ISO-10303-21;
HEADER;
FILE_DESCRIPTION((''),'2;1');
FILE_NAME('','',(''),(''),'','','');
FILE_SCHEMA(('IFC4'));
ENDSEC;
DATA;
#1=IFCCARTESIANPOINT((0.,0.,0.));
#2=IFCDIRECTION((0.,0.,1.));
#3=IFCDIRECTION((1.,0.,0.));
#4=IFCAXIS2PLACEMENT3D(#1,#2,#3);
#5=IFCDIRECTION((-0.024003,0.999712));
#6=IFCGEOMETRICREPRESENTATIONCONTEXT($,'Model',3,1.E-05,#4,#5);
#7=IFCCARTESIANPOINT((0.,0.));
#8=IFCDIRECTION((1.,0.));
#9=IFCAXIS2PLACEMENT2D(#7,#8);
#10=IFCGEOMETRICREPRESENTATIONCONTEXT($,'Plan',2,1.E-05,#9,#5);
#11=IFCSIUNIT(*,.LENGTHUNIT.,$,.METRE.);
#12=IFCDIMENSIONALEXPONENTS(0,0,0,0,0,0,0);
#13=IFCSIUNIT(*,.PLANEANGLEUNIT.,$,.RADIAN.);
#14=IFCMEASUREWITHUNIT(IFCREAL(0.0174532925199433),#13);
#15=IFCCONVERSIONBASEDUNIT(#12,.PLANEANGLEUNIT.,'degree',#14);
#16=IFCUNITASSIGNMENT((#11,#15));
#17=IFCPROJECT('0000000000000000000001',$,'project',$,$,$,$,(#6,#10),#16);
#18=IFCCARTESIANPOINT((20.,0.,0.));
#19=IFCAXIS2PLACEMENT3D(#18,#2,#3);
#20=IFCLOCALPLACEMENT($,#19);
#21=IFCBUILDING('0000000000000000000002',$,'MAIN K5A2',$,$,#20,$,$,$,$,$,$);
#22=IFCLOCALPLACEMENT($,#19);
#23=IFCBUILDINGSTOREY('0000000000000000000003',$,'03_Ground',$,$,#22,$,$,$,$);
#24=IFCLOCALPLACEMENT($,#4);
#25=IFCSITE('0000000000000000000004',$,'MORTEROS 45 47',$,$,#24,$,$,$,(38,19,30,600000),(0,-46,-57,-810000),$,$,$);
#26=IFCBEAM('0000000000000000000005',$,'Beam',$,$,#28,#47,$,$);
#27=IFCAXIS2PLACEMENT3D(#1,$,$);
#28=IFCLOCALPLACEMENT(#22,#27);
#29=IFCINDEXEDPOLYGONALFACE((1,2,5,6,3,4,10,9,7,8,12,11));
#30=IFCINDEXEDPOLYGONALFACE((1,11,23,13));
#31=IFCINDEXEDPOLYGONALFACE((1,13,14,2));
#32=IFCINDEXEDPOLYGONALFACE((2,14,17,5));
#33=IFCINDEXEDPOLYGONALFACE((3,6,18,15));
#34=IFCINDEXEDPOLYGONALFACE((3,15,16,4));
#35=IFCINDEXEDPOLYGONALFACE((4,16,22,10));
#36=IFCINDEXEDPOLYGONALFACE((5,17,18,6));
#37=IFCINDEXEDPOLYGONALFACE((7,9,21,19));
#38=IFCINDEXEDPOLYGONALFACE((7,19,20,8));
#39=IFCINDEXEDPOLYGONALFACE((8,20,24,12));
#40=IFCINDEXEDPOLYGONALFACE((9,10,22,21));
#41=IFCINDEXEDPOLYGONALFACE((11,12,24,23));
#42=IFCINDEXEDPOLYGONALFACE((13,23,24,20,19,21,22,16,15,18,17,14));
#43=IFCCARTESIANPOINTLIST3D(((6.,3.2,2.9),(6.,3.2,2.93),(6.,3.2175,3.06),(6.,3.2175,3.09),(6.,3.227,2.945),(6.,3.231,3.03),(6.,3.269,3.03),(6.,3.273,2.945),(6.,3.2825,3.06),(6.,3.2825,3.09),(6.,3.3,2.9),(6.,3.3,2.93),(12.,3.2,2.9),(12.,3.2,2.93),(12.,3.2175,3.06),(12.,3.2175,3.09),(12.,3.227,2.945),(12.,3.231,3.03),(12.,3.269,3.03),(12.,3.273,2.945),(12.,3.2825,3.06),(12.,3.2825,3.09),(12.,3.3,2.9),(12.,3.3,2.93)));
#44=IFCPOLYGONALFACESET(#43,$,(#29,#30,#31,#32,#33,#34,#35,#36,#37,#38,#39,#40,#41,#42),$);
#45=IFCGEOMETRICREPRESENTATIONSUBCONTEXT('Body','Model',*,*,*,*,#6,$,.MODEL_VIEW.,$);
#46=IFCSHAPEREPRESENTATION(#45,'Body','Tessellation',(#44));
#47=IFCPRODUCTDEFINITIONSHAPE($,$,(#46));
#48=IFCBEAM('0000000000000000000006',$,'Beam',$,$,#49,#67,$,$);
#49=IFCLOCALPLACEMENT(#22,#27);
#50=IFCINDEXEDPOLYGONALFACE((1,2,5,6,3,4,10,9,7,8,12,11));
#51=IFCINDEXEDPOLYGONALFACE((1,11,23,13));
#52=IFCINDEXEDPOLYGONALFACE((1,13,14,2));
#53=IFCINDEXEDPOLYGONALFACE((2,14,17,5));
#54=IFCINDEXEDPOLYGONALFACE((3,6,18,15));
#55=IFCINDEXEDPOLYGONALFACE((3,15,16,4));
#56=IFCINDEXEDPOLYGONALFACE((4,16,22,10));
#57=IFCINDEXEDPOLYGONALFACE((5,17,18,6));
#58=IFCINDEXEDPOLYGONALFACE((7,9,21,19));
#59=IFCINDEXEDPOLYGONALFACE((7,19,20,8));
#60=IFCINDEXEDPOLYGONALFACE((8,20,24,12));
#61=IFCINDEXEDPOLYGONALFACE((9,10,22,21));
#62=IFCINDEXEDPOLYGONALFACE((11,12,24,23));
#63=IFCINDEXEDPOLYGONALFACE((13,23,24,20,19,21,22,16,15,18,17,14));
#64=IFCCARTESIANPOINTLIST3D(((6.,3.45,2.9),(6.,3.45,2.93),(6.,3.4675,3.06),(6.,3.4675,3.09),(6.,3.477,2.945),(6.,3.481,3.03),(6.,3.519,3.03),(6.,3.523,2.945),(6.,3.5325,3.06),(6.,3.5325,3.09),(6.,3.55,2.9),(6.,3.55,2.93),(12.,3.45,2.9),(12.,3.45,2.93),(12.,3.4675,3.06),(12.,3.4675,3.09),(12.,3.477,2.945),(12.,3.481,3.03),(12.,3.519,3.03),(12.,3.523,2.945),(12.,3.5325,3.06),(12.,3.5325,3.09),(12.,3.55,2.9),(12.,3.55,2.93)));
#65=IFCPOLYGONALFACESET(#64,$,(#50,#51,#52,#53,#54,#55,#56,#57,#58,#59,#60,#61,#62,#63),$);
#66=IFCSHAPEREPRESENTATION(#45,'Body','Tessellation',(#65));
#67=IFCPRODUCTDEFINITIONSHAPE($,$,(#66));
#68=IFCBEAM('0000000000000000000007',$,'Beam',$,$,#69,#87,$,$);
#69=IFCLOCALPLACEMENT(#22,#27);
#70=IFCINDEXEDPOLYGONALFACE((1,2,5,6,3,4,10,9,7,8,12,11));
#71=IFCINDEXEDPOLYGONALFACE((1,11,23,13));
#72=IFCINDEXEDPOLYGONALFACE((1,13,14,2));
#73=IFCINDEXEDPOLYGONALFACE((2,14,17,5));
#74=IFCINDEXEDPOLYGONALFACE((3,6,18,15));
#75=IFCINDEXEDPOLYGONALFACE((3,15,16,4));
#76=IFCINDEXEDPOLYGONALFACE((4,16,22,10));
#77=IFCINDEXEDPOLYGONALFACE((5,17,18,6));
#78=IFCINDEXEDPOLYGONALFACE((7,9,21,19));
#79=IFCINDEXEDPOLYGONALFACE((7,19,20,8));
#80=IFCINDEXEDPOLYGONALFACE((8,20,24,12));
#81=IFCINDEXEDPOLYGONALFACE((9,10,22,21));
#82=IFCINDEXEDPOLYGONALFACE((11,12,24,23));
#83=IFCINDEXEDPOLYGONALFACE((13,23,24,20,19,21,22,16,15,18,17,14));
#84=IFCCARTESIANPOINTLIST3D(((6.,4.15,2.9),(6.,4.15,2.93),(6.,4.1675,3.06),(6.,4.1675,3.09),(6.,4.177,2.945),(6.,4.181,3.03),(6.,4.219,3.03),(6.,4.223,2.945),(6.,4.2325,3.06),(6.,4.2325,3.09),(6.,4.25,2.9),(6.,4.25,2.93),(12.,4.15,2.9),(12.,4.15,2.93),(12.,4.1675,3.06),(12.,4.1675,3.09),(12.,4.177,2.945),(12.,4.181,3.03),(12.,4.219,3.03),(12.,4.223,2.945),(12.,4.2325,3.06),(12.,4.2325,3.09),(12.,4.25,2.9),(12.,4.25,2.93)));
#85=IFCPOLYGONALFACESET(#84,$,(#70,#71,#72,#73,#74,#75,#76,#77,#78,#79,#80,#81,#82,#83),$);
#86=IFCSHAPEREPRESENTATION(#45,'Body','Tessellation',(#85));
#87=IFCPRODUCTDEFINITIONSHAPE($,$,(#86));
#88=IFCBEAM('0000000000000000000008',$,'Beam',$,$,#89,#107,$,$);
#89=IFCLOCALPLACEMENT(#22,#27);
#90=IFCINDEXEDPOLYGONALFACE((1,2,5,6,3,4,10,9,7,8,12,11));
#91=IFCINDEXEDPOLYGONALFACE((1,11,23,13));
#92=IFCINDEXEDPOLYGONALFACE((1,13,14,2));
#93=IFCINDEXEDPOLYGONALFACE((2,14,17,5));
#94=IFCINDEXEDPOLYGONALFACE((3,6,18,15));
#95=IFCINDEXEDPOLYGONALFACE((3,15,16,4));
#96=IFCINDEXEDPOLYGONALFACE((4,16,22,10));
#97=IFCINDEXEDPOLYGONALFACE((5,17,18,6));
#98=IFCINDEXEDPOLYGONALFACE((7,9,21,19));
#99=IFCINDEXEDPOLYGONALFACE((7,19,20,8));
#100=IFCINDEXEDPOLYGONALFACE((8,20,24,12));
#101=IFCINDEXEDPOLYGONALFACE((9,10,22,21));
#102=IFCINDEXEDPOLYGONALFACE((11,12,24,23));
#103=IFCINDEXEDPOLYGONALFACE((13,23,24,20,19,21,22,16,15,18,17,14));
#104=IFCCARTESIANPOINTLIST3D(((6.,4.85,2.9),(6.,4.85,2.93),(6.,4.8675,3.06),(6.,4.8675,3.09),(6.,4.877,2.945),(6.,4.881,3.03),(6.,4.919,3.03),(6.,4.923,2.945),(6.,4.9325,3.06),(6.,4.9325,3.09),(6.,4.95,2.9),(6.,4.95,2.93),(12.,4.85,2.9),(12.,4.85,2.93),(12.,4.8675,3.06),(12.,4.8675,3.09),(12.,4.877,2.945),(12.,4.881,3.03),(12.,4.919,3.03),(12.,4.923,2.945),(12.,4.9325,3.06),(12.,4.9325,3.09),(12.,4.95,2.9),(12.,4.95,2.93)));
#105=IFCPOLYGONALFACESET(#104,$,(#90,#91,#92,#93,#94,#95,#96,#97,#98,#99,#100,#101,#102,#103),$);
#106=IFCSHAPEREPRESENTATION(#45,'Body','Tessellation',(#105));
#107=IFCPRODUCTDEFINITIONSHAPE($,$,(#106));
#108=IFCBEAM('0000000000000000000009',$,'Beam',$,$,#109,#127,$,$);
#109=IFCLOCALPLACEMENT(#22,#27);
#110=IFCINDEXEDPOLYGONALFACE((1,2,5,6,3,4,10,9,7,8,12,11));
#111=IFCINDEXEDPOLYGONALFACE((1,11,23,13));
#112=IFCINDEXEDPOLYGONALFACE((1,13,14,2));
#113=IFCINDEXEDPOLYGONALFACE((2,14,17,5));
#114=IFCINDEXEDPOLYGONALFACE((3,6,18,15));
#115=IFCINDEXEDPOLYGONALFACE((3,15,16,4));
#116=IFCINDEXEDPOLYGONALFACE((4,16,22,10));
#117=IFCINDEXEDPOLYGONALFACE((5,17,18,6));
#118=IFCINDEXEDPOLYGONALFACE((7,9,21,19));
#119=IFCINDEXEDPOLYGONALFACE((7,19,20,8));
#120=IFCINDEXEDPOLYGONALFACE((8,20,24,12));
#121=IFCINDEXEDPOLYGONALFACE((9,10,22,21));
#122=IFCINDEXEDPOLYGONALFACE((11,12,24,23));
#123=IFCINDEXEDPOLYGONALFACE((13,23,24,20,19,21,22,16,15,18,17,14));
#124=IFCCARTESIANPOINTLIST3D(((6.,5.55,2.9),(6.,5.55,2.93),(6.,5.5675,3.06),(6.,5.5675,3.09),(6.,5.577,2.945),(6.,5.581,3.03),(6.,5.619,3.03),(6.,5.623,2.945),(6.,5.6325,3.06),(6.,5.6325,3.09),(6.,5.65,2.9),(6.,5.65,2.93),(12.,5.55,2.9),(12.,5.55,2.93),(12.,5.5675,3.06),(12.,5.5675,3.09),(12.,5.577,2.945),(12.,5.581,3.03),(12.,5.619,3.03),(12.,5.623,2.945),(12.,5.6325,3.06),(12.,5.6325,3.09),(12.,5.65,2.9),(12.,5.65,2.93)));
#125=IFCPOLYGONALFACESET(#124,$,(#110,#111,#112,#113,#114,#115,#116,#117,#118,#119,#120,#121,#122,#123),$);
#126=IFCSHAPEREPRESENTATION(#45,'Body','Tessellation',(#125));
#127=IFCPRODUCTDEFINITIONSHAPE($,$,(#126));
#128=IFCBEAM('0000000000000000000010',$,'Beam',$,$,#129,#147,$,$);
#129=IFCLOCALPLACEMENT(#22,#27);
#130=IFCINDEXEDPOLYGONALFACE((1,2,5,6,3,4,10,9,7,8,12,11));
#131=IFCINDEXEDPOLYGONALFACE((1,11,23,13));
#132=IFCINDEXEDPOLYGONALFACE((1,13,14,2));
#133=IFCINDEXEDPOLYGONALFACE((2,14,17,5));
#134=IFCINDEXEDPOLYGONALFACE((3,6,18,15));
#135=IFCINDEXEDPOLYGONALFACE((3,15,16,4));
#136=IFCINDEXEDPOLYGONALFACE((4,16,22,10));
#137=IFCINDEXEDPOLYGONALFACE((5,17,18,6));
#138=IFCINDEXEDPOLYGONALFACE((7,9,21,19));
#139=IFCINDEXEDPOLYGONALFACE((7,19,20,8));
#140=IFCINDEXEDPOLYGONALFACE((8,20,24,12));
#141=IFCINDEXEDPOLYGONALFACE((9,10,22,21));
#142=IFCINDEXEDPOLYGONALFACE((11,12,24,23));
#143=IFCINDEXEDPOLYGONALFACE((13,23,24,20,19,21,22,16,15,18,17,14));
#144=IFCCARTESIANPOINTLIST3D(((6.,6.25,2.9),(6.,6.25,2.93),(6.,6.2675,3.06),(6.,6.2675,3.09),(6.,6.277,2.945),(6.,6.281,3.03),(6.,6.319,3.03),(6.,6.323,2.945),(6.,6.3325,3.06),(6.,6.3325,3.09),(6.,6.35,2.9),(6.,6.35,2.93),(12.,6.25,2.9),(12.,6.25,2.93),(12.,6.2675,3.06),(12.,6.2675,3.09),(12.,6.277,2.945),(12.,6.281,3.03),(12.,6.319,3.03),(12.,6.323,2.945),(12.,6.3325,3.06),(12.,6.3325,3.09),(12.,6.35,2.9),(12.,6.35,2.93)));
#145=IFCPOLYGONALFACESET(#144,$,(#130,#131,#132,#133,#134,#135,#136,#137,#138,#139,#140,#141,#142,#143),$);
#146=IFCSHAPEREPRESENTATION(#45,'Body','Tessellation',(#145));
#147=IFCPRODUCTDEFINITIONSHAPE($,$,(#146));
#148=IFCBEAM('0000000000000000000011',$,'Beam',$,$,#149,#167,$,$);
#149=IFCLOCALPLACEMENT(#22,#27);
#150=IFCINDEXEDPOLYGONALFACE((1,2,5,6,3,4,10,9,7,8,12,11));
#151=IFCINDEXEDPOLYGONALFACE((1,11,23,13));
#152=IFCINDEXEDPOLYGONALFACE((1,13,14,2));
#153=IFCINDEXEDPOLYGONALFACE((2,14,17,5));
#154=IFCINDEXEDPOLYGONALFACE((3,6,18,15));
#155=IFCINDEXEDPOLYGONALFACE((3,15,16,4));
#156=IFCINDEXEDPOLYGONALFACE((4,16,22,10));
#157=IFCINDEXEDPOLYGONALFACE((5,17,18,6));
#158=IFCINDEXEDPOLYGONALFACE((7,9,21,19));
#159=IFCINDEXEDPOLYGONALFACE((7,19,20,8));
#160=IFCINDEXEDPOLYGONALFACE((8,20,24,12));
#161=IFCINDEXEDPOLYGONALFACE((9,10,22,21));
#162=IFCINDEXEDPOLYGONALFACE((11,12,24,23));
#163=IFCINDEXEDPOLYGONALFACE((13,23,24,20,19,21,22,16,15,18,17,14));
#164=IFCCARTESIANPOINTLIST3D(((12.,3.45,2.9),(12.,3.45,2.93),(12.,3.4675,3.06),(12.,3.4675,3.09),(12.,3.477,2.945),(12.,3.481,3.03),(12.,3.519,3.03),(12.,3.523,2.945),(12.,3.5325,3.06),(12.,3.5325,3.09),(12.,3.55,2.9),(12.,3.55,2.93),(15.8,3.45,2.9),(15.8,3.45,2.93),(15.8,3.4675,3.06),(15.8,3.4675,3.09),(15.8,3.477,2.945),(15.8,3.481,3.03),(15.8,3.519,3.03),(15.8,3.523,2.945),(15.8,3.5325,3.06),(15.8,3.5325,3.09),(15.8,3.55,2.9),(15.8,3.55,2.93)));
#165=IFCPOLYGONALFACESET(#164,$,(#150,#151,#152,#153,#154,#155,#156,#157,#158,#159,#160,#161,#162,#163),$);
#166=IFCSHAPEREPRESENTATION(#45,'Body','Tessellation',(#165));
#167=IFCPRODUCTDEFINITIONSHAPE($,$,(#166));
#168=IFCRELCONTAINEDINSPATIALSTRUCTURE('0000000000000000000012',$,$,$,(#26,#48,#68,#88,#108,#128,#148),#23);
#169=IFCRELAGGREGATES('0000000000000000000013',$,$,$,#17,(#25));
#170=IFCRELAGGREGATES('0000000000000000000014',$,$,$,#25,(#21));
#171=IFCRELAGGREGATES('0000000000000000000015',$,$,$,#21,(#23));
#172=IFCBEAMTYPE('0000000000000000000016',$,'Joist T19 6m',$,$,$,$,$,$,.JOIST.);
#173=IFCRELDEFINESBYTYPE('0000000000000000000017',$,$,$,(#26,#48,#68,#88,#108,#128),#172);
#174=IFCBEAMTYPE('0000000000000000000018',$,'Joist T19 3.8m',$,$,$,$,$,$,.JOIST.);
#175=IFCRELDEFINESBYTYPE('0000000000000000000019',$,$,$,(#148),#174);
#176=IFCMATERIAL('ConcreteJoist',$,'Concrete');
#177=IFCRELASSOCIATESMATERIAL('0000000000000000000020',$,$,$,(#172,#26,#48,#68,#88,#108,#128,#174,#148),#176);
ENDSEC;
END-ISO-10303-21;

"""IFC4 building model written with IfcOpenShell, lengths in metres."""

from ifc_helpers import new_model, entity, si_unit, converted_unit, direction, frame, origin_with_axes, origin_2d_with_axis, place, context, subcontext, project, spatial, indexed_curve, outline, extrude, material, material_profile, profile_set, profile_usage, type_object, element, save


model = new_model("IFC4")

# Units and contexts
model_context = context("Model", 3, precision=1e-05, world=origin_with_axes(), true_north=direction((-0.024003, 0.999712)))
plan_context = context("Plan", 2, precision=1e-05, world=origin_2d_with_axis(), true_north=direction((-0.024003, 0.999712)))
body_context_1 = subcontext(model_context, "Body", "Model", "MODEL_VIEW")
ifc_project = project(units=[si_unit("LENGTHUNIT", "METRE"), converted_unit("PLANEANGLEUNIT", "degree", entity("IfcReal", 0.0174532925199433), si_unit("PLANEANGLEUNIT", "RADIAN"), dimensions=[0, 0, 0, 0, 0, 0, 0])], contexts=[model_context, plan_context])

# Site, building, storey
site_placement = place(None, origin_with_axes())
site = spatial("IfcSite", under=ifc_project, at=site_placement, Name="MORTEROS 45 47", RefLatitude=(38, 19, 30, 600000), RefLongitude=(0, -46, -57, -810000))
building_placement = place(None, frame((20.0, 0.0, 0.0), z_axis=(0.0, 0.0, 1.0), x_axis=(1.0, 0.0, 0.0)))
building = spatial("IfcBuilding", under=site, at=building_placement, Name="MAIN K5A2")
storey_placement = place(None, frame((20.0, 0.0, 0.0), z_axis=(0.0, 0.0, 1.0), x_axis=(1.0, 0.0, 0.0)))
storey = spatial("IfcBuildingStorey", under=building, at=storey_placement, Name="03_Ground")

# Beams
ifc_material = material(Name="ConcreteJoist", Category="Concrete")
ifc_material_profile_1 = material_profile(ifc_material, outline(indexed_curve([(0.019, 0.13), (0.023, 0.045), (0.05, 0.03), (0.05, 0.0), (-0.05, 0.0), (-0.05, 0.03), (-0.023, 0.045), (-0.019, 0.13), (-0.0325, 0.16), (-0.0325, 0.19), (0.0325, 0.19), (0.0325, 0.16), (0.019, 0.13)])))
ifc_profile_set_1 = profile_set([ifc_material_profile_1], Name="JoistmaterialProfile")
ifc_profile_usage_1 = profile_usage(ifc_profile_set_1)
beam_type_1 = type_object("IfcBeamType", Name="Joist T19 6m", PredefinedType="JOIST", material=ifc_profile_set_1)
beam_1_placement = place(None, frame((26.0, 3.25, 2.9), z_axis=(1.0, 0.0, 0.0), x_axis=(0.0, 1.0, 0.0)))
element("IfcBeam", 1, at=beam_1_placement, inside=storey, type_object=beam_type_1, material=ifc_profile_usage_1, Name="Beam", context=body_context_1, shape_type="SweptSolid", body=[
    extrude(outline(indexed_curve([(0.019, 0.13), (0.023, 0.045), (0.05, 0.03), (0.05, 0.0), (-0.05, 0.0), (-0.05, 0.03), (-0.023, 0.045), (-0.019, 0.13), (-0.0325, 0.16), (-0.0325, 0.19), (0.0325, 0.19), (0.0325, 0.16), (0.019, 0.13)])), origin_with_axes(), (0.0, 0.0, 1.0), 6.0),
])
ifc_profile_usage_2 = profile_usage(ifc_profile_set_1)
beam_2_placement = place(None, frame((26.0, 3.5, 2.9), z_axis=(1.0, 0.0, 0.0), x_axis=(0.0, 1.0, 0.0)))
element("IfcBeam", 2, at=beam_2_placement, inside=storey, type_object=beam_type_1, material=ifc_profile_usage_2, Name="Beam", context=body_context_1, shape_type="SweptSolid", body=[
    extrude(outline(indexed_curve([(0.019, 0.13), (0.023, 0.045), (0.05, 0.03), (0.05, 0.0), (-0.05, 0.0), (-0.05, 0.03), (-0.023, 0.045), (-0.019, 0.13), (-0.0325, 0.16), (-0.0325, 0.19), (0.0325, 0.19), (0.0325, 0.16), (0.019, 0.13)])), origin_with_axes(), (0.0, 0.0, 1.0), 6.0),
])
ifc_profile_usage_3 = profile_usage(ifc_profile_set_1)
beam_3_placement = place(None, frame((26.0, 4.2, 2.9), z_axis=(1.0, 0.0, 0.0), x_axis=(0.0, 1.0, 0.0)))
element("IfcBeam", 3, at=beam_3_placement, inside=storey, type_object=beam_type_1, material=ifc_profile_usage_3, Name="Beam", context=body_context_1, shape_type="SweptSolid", body=[
    extrude(outline(indexed_curve([(0.019, 0.13), (0.023, 0.045), (0.05, 0.03), (0.05, 0.0), (-0.05, 0.0), (-0.05, 0.03), (-0.023, 0.045), (-0.019, 0.13), (-0.0325, 0.16), (-0.0325, 0.19), (0.0325, 0.19), (0.0325, 0.16), (0.019, 0.13)])), origin_with_axes(), (0.0, 0.0, 1.0), 6.0),
])
ifc_profile_usage_4 = profile_usage(ifc_profile_set_1)
beam_4_placement = place(None, frame((26.0, 4.9, 2.9), z_axis=(1.0, 0.0, 0.0), x_axis=(0.0, 1.0, 0.0)))
element("IfcBeam", 4, at=beam_4_placement, inside=storey, type_object=beam_type_1, material=ifc_profile_usage_4, Name="Beam", context=body_context_1, shape_type="SweptSolid", body=[
    extrude(outline(indexed_curve([(0.019, 0.13), (0.023, 0.045), (0.05, 0.03), (0.05, 0.0), (-0.05, 0.0), (-0.05, 0.03), (-0.023, 0.045), (-0.019, 0.13), (-0.0325, 0.16), (-0.0325, 0.19), (0.0325, 0.19), (0.0325, 0.16), (0.019, 0.13)])), origin_with_axes(), (0.0, 0.0, 1.0), 6.0),
])
ifc_profile_usage_5 = profile_usage(ifc_profile_set_1)
beam_5_placement = place(None, frame((26.0, 5.6, 2.9), z_axis=(1.0, 0.0, 0.0), x_axis=(0.0, 1.0, 0.0)))
element("IfcBeam", 5, at=beam_5_placement, inside=storey, type_object=beam_type_1, material=ifc_profile_usage_5, Name="Beam", context=body_context_1, shape_type="SweptSolid", body=[
    extrude(outline(indexed_curve([(0.019, 0.13), (0.023, 0.045), (0.05, 0.03), (0.05, 0.0), (-0.05, 0.0), (-0.05, 0.03), (-0.023, 0.045), (-0.019, 0.13), (-0.0325, 0.16), (-0.0325, 0.19), (0.0325, 0.19), (0.0325, 0.16), (0.019, 0.13)])), origin_with_axes(), (0.0, 0.0, 1.0), 6.0),
])
ifc_profile_usage_6 = profile_usage(ifc_profile_set_1)
beam_6_placement = place(None, frame((26.0, 6.3, 2.9), z_axis=(1.0, 0.0, 0.0), x_axis=(0.0, 1.0, 0.0)))
element("IfcBeam", 6, at=beam_6_placement, inside=storey, type_object=beam_type_1, material=ifc_profile_usage_6, Name="Beam", context=body_context_1, shape_type="SweptSolid", body=[
    extrude(outline(indexed_curve([(0.019, 0.13), (0.023, 0.045), (0.05, 0.03), (0.05, 0.0), (-0.05, 0.0), (-0.05, 0.03), (-0.023, 0.045), (-0.019, 0.13), (-0.0325, 0.16), (-0.0325, 0.19), (0.0325, 0.19), (0.0325, 0.16), (0.019, 0.13)])), origin_with_axes(), (0.0, 0.0, 1.0), 6.0),
])
ifc_material_profile_2 = material_profile(ifc_material, outline(indexed_curve([(0.019, 0.13), (0.023, 0.045), (0.05, 0.03), (0.05, 0.0), (-0.05, 0.0), (-0.05, 0.03), (-0.023, 0.045), (-0.019, 0.13), (-0.0325, 0.16), (-0.0325, 0.19), (0.0325, 0.19), (0.0325, 0.16), (0.019, 0.13)])))
ifc_profile_set_2 = profile_set([ifc_material_profile_2], Name="JoistMaterialProfileSet")
ifc_profile_usage_7 = profile_usage(ifc_profile_set_2)
ifc_material_profile_3 = material_profile(ifc_material, outline(indexed_curve([(0.019, 0.13), (0.023, 0.045), (0.05, 0.03), (0.05, 0.0), (-0.05, 0.0), (-0.05, 0.03), (-0.023, 0.045), (-0.019, 0.13), (-0.0325, 0.16), (-0.0325, 0.19), (0.0325, 0.19), (0.0325, 0.16), (0.019, 0.13)])))
ifc_profile_set_3 = profile_set([ifc_material_profile_3], Name="JoistMaterialProfileSet")
beam_type_2 = type_object("IfcBeamType", Name="Joist T19 3.8m", PredefinedType="JOIST", material=ifc_profile_set_3)
beam_7_placement = place(None, frame((32.0, 3.5, 2.9), z_axis=(1.0, 0.0, 0.0), x_axis=(0.0, 1.0, 0.0)))
element("IfcBeam", 7, at=beam_7_placement, inside=storey, type_object=beam_type_2, material=ifc_profile_usage_7, Name="Beam", context=body_context_1, shape_type="SweptSolid", body=[
    extrude(outline(indexed_curve([(0.019, 0.13), (0.023, 0.045), (0.05, 0.03), (0.05, 0.0), (-0.05, 0.0), (-0.05, 0.03), (-0.023, 0.045), (-0.019, 0.13), (-0.0325, 0.16), (-0.0325, 0.19), (0.0325, 0.19), (0.0325, 0.16), (0.019, 0.13)])), origin_with_axes(), (0.0, 0.0, 1.0), 3.8),
])

save(model, "model.ifc")
